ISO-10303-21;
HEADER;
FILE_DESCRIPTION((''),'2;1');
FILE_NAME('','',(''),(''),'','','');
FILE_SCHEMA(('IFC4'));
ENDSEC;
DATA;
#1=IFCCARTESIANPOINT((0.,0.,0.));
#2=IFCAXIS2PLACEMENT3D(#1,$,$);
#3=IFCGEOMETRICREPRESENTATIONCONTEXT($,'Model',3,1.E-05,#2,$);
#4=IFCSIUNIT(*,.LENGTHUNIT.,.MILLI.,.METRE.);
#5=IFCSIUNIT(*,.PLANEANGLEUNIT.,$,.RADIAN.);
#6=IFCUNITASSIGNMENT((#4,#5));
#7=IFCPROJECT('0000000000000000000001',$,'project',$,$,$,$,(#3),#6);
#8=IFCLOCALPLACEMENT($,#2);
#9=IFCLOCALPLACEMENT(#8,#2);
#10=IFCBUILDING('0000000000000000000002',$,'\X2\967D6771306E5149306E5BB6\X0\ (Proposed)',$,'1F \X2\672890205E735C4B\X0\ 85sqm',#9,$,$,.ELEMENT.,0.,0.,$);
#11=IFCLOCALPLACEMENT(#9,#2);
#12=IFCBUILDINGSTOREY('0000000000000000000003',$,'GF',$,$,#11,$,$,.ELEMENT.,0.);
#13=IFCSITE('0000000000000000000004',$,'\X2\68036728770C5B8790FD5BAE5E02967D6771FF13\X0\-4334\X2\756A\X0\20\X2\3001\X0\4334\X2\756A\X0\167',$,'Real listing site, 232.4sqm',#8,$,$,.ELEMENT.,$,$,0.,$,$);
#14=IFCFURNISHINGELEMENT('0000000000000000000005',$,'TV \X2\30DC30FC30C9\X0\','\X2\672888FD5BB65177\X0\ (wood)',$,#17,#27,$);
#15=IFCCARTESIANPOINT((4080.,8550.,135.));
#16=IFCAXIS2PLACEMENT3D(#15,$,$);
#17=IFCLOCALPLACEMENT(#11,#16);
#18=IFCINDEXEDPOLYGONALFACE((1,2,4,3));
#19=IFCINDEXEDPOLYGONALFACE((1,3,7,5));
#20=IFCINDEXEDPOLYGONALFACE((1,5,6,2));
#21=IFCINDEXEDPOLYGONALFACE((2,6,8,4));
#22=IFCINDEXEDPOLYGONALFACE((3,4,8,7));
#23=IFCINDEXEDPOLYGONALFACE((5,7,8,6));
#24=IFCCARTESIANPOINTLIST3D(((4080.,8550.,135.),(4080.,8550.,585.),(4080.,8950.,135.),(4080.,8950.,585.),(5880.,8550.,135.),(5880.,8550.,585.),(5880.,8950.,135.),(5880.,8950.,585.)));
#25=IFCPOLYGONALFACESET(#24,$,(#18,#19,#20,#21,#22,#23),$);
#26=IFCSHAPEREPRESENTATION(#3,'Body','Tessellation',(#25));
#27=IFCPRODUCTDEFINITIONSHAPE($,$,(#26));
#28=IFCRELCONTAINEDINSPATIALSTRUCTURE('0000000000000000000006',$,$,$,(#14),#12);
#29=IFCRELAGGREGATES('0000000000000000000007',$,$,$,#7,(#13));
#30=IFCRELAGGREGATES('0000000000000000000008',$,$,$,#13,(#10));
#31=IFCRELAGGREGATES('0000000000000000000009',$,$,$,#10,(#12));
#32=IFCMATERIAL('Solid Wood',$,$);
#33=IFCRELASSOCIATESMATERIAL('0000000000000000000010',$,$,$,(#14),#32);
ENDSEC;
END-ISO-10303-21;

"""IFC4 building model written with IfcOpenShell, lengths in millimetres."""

from ifc_helpers import new_model, si_unit, frame, frame_2d, origin, place, context, project, spatial, rectangle, extrude, material, element, save


model = new_model("IFC4")

# Units and contexts
model_context = context("Model", 3, precision=1e-05, world=origin())
ifc_project = project(units=[si_unit("LENGTHUNIT", "METRE", prefix="MILLI"), si_unit("PLANEANGLEUNIT", "RADIAN")], contexts=[model_context])

# Site, building, storey
site_placement = place(None, origin())
site = spatial("IfcSite", under=ifc_project, at=site_placement, Name="栃木県宇都宮市陽東３-4334番20、4334番167", ObjectType="Real listing site, 232.4sqm", CompositionType="ELEMENT", RefElevation=0.0)
building_placement = place(site_placement, origin())
building = spatial("IfcBuilding", under=site, at=building_placement, Name="陽東の光の家 (Proposed)", ObjectType="1F 木造平屋 85sqm", CompositionType="ELEMENT", ElevationOfRefHeight=0.0, ElevationOfTerrain=0.0)
storey_placement = place(building_placement, origin())
storey = spatial("IfcBuildingStorey", under=building, at=storey_placement, Name="GF", CompositionType="ELEMENT", Elevation=0.0)

# Shared definitions
ifc_material_1 = material(Name="Solid Wood")

# Furnishing element
furnishing_placement = place(storey_placement, frame((4080.0, 8550.0, 135.0)))
element("IfcFurnishingElement", 1, at=furnishing_placement, inside=storey, material=ifc_material_1, Name="TV ボード", Description="木製家具 (wood)", context=model_context, shape_type="SweptSolid", body=[
    extrude(rectangle(XDim=1800.0, YDim=400.0, at=frame_2d((900.0, 200.0))), frame((4080.0, 8550.0, 135.0)), (0.0, 0.0, 1.0), 450.0),
])

save(model, "model.ifc")
